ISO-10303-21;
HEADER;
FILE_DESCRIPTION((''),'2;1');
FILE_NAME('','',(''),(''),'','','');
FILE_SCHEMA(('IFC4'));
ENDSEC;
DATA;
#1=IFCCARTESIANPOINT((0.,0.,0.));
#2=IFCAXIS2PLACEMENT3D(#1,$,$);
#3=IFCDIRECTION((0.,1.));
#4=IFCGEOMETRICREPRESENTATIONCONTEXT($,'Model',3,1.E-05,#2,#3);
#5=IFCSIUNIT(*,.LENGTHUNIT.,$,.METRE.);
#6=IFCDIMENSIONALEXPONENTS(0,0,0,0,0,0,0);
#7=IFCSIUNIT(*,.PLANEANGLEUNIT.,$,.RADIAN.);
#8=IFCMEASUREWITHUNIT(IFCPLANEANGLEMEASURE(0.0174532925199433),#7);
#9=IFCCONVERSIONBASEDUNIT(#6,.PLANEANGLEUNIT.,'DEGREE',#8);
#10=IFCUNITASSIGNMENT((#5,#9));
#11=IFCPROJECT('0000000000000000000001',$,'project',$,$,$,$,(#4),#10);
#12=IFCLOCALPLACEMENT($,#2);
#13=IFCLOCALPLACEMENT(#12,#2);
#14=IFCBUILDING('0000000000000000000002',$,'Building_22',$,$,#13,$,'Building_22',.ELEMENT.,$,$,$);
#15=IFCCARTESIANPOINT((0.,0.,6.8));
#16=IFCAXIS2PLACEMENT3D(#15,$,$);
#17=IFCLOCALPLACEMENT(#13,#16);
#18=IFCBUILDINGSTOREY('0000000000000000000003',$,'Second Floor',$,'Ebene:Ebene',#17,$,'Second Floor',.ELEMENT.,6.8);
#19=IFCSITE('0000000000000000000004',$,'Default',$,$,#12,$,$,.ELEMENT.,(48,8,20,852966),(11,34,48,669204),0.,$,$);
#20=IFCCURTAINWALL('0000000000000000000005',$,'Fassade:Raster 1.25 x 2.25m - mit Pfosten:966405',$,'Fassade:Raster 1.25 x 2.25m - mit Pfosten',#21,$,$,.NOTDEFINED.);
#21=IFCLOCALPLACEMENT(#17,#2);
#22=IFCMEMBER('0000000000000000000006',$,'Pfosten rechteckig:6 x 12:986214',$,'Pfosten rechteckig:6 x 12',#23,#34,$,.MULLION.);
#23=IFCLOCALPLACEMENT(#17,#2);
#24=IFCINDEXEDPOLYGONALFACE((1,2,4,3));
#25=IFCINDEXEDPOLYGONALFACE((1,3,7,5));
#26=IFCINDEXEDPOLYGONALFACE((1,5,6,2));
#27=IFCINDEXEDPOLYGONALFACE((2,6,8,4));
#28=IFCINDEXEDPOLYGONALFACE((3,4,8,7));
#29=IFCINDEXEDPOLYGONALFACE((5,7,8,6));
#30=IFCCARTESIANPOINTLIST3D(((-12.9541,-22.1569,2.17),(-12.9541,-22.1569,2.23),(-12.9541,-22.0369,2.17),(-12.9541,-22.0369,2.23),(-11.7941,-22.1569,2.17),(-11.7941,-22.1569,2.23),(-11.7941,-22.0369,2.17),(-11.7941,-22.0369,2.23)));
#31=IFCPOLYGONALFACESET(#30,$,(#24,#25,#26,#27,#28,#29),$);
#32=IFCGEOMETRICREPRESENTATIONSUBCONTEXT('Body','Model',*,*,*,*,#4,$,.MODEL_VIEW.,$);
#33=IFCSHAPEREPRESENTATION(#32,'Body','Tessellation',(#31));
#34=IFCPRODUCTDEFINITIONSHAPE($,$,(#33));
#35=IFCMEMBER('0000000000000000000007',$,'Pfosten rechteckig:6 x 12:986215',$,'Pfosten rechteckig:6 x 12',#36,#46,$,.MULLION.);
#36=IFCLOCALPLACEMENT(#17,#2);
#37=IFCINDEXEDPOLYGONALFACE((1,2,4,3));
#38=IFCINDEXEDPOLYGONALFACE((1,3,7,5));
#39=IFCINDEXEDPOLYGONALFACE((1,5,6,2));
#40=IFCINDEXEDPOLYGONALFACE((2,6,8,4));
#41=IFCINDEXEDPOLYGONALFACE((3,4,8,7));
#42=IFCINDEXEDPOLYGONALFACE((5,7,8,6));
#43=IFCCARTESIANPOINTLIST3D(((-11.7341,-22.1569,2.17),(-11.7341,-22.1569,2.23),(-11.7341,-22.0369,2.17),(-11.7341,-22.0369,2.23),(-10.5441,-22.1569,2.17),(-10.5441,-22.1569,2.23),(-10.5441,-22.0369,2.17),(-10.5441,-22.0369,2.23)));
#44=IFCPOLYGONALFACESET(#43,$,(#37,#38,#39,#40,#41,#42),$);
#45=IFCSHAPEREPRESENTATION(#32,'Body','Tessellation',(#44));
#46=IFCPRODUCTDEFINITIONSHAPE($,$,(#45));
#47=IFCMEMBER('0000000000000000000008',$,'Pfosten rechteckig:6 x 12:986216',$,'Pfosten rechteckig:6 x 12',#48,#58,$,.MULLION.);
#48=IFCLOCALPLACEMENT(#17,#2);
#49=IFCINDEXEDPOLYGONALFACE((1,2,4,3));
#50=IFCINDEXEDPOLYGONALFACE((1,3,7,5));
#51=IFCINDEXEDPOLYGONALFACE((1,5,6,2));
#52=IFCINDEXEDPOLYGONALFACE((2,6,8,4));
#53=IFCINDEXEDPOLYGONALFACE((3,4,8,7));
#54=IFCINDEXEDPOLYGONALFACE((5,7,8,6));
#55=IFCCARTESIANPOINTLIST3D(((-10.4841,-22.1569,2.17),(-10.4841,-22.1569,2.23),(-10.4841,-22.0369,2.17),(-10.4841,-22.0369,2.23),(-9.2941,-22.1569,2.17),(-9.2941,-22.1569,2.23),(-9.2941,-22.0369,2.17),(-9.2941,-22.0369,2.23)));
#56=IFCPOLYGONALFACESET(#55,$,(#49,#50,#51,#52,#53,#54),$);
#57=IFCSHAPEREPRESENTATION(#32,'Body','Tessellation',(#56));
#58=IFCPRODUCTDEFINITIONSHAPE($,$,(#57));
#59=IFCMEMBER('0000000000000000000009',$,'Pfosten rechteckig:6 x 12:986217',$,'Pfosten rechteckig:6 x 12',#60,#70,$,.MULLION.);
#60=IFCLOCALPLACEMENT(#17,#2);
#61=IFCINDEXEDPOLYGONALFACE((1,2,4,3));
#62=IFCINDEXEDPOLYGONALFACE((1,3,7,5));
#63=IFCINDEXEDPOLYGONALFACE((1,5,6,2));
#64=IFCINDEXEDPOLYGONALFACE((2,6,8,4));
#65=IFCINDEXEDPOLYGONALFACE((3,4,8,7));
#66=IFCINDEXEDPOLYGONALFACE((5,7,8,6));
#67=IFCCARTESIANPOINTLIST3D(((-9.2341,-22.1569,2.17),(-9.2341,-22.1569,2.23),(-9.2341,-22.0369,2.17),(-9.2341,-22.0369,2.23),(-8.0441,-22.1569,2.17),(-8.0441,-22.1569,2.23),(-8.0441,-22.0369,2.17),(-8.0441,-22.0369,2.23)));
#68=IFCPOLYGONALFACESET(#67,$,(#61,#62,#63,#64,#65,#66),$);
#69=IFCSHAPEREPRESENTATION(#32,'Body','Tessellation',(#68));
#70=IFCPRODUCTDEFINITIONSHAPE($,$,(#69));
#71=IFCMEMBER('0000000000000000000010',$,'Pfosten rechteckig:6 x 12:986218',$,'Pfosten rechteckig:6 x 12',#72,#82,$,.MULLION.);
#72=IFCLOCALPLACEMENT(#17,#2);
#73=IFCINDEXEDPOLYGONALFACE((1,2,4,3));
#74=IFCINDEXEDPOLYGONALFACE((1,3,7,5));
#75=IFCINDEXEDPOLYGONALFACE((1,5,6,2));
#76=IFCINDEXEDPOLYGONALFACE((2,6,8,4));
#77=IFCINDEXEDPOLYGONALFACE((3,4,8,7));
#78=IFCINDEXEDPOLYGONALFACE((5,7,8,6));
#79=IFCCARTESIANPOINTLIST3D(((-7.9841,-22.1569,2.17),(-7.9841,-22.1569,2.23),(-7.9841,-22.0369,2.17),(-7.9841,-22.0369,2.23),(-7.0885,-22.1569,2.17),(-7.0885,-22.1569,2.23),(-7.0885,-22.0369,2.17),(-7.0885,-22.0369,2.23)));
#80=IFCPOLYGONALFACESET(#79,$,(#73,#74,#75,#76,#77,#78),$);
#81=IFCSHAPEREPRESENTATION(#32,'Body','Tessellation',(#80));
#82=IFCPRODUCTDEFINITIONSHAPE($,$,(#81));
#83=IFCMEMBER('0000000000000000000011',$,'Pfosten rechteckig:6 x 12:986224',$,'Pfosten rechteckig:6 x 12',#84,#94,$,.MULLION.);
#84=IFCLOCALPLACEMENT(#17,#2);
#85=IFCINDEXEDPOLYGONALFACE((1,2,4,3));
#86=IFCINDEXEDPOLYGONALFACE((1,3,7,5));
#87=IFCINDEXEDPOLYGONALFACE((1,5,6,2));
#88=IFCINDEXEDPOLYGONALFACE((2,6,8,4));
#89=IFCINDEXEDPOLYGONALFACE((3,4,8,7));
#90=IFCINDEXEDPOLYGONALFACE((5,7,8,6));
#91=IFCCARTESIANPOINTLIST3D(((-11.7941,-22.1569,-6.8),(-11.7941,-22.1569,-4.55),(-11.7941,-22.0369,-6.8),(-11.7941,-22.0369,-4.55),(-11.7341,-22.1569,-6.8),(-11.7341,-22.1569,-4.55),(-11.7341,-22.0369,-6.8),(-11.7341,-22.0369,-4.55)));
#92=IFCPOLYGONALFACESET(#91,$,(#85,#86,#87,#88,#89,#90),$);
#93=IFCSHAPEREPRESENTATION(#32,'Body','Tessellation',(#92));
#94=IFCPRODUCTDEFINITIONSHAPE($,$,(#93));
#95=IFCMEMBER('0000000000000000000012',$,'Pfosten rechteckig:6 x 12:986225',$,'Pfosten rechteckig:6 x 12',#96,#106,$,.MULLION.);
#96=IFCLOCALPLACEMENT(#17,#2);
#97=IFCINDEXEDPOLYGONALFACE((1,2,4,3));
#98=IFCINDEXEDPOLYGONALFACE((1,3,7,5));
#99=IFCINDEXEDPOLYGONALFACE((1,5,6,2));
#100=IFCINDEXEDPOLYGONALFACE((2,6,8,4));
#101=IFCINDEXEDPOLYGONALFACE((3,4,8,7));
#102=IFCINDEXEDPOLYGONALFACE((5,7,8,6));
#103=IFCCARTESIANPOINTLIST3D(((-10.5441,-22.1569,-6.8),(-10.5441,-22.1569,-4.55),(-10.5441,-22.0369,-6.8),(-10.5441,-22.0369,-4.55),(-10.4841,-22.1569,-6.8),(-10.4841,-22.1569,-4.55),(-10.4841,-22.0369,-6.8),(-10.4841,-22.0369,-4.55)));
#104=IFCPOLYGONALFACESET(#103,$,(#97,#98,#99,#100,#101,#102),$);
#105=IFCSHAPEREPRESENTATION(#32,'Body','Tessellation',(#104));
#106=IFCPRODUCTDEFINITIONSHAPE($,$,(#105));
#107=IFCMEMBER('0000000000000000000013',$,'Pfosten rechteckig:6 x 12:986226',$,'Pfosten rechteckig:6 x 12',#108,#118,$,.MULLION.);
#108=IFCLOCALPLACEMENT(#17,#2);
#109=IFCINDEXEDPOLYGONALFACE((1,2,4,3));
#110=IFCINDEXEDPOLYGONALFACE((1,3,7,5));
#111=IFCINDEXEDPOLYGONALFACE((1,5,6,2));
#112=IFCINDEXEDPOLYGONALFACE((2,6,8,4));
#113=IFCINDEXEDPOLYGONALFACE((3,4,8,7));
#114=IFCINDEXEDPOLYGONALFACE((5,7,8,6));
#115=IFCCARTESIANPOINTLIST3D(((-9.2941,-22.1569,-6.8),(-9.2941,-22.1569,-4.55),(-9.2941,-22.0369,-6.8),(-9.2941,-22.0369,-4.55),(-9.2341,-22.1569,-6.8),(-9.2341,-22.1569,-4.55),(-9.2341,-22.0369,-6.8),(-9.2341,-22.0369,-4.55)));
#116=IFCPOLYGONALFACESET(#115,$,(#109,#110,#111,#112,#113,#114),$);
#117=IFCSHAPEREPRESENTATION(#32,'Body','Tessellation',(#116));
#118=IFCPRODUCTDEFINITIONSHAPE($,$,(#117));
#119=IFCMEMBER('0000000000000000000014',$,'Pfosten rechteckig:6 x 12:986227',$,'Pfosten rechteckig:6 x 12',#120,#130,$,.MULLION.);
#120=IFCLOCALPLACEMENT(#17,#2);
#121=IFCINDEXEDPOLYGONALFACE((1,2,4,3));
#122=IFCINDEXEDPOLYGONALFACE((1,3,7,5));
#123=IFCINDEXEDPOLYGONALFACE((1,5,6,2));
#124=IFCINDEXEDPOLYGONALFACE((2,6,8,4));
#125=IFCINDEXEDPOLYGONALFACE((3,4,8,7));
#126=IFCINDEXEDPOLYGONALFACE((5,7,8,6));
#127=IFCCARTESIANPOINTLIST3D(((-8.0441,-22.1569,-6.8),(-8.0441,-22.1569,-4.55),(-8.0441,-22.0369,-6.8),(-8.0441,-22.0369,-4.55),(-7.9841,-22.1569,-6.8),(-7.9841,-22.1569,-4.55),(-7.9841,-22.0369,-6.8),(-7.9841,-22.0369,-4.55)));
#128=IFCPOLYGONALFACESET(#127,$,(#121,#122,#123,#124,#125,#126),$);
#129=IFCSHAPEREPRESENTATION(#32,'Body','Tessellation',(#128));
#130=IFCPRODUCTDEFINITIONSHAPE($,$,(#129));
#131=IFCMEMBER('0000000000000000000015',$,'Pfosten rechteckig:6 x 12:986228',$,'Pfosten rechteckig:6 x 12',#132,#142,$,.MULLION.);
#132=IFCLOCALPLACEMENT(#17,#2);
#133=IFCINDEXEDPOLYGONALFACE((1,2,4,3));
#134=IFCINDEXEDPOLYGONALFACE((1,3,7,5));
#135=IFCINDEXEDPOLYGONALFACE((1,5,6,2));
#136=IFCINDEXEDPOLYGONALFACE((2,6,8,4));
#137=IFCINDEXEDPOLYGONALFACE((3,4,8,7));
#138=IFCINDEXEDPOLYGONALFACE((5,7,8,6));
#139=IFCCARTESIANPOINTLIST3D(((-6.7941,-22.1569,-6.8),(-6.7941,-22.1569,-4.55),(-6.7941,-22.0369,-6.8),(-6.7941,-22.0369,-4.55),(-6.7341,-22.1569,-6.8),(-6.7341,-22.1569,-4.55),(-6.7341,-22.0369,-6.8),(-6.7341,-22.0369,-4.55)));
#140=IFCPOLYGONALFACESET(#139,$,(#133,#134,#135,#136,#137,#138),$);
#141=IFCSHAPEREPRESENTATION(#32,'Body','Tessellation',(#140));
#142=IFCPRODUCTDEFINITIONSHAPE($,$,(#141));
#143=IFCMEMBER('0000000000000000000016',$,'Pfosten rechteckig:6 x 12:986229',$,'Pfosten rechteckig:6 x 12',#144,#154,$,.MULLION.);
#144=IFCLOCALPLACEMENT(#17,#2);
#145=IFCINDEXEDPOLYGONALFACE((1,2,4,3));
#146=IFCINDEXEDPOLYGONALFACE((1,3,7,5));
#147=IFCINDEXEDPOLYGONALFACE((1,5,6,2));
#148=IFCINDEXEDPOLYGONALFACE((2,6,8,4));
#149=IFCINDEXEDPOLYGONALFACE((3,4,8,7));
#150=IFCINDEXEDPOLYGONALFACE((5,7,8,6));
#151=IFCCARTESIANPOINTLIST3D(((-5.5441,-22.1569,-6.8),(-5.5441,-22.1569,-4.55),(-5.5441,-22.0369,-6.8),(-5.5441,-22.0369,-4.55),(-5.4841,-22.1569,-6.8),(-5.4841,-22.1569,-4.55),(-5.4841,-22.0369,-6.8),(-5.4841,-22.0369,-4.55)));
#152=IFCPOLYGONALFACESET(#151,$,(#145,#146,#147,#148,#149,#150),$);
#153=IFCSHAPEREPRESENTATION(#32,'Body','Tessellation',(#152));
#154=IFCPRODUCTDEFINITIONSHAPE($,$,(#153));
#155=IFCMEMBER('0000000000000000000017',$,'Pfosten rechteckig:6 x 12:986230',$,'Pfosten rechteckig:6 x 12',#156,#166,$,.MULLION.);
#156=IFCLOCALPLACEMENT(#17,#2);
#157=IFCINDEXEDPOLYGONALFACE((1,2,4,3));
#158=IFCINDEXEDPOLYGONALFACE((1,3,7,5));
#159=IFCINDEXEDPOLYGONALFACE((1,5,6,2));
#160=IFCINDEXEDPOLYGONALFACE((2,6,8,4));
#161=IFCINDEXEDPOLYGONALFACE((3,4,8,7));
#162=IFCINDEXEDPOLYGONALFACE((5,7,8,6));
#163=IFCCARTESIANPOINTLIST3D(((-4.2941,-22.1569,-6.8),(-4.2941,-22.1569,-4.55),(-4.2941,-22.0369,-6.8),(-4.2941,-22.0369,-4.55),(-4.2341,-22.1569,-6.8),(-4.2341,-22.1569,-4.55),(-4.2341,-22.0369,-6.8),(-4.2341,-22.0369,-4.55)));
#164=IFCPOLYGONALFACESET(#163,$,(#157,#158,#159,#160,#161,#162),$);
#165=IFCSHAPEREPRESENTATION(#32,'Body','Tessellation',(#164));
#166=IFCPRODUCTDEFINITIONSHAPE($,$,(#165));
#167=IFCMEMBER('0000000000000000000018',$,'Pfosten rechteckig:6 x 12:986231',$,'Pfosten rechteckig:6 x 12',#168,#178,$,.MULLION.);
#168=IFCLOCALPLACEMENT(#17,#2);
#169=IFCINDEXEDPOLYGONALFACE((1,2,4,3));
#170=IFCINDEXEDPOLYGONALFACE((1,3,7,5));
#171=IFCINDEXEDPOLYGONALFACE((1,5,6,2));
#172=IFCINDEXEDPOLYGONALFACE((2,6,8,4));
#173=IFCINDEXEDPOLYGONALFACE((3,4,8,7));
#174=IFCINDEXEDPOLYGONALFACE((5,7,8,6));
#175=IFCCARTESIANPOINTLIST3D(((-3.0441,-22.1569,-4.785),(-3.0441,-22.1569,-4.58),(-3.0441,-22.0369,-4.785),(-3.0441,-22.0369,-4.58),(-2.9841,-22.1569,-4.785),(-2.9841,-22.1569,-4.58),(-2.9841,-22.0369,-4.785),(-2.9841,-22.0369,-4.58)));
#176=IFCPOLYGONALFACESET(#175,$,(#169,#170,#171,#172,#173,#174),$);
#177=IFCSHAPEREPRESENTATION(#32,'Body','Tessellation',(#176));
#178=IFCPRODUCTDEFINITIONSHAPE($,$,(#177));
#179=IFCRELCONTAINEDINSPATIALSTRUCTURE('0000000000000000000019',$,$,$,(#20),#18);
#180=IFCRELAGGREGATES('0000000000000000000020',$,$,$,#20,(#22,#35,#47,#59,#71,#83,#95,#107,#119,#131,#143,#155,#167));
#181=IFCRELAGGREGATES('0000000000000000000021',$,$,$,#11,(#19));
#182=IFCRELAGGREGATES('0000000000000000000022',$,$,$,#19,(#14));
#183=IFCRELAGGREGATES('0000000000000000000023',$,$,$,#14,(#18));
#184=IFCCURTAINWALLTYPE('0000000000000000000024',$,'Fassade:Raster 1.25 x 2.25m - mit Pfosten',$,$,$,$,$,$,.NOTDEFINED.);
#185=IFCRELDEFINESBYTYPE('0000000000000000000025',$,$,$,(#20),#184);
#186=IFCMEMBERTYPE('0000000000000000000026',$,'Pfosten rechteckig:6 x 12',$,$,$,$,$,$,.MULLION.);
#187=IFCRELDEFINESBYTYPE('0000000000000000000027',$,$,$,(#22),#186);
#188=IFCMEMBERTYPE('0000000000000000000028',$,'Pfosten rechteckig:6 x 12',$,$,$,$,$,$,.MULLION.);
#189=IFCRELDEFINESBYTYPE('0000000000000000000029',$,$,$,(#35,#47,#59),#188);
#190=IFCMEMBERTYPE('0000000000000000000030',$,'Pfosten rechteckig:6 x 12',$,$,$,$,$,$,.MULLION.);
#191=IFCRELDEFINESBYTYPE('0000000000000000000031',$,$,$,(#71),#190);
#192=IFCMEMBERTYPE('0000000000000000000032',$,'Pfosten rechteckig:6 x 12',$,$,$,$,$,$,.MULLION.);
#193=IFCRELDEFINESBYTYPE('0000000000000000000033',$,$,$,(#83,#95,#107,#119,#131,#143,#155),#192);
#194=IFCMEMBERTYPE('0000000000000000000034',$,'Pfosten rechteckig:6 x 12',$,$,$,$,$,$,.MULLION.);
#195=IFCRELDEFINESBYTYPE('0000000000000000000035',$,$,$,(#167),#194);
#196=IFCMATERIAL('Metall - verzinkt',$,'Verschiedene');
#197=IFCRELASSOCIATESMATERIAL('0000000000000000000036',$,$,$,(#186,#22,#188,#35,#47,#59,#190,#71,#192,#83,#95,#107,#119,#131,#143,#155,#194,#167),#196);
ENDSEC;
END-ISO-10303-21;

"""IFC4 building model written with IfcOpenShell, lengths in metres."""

from ifc_helpers import new_model, entity, si_unit, converted_unit, direction, frame, origin, place, context, subcontext, project, spatial, indexed_curve, outline, extrude, source, transform, mapped, material, type_object, type_shapes, element, aggregate, save


model = new_model("IFC4")

# Units and contexts
model_context = context("Model", 3, precision=1e-05, world=origin(), true_north=direction((0.0, 1.0)))
body_context = subcontext(model_context, "Body", "Model", "MODEL_VIEW")
ifc_project = project(units=[si_unit("LENGTHUNIT", "METRE"), converted_unit("PLANEANGLEUNIT", "DEGREE", entity("IfcPlaneAngleMeasure", 0.0174532925199433), si_unit("PLANEANGLEUNIT", "RADIAN"), dimensions=[0, 0, 0, 0, 0, 0, 0])], contexts=[model_context])

# Site, building, storey
site_placement = place(None, origin())
site = spatial("IfcSite", under=ifc_project, at=site_placement, Name="Default", CompositionType="ELEMENT", RefLatitude=(48, 8, 20, 852966), RefLongitude=(11, 34, 48, 669204), RefElevation=0.0)
building_placement = place(site_placement, origin())
building = spatial("IfcBuilding", under=site, at=building_placement, Name="Building_22", LongName="Building_22", CompositionType="ELEMENT")
storey_placement = place(building_placement, frame((0.0, 0.0, 6.8)))
storey = spatial("IfcBuildingStorey", under=building, at=storey_placement, Name="Second Floor", ObjectType="Ebene:Ebene", LongName="Second Floor", CompositionType="ELEMENT", Elevation=6.8)

# Curtain wall, members
curtain_wall_type = type_object("IfcCurtainWallType", Name="Fassade:Raster 1.25 x 2.25m - mit Pfosten", PredefinedType="NOTDEFINED")
curtain_wall_placement = place(storey_placement, frame((0.0, 0.0, -6.8)))
curtain_wall = element("IfcCurtainWall", 1, at=curtain_wall_placement, inside=storey, type_object=curtain_wall_type, Name="Fassade:Raster 1.25 x 2.25m - mit Pfosten:966405", ObjectType="Fassade:Raster 1.25 x 2.25m - mit Pfosten", PredefinedType="NOTDEFINED")
ifc_material = material(Name="Metall - verzinkt", Category="Verschiedene")
member_type_1 = type_object("IfcMemberType", Name="Pfosten rechteckig:6 x 12", PredefinedType="MULLION", material=ifc_material)
shared_shape_1 = source(origin(), body_context, "Body", "SweptSolid", [
    extrude(outline(indexed_curve([(-0.03, -0.06), (0.03, -0.06), (0.03, 0.06), (-0.03, 0.06), (-0.03, -0.06)], self_intersect=False)), frame((0.0, 0.0, -1.16), z_axis=(0.0, 0.0, 1.0), x_axis=(-1.0, 0.0, 0.0)), (0.0, 0.0, 1.0), 1.16),
])
type_shapes(member_type_1, [shared_shape_1])
member_1_placement = place(curtain_wall_placement, frame((-11.7941, -22.0969, 9.0), z_axis=(1.0, 0.0, 0.0), x_axis=(0.0, 0.0, 1.0)))
member_1 = element("IfcMember", 2, at=member_1_placement, type_object=member_type_1, material=ifc_material, Name="Pfosten rechteckig:6 x 12:986214", ObjectType="Pfosten rechteckig:6 x 12", PredefinedType="MULLION", context=body_context, shape_type="MappedRepresentation", body=[
    mapped(shared_shape_1, transform((0.0, 0.0, 0.0), scale=1.0)),
])
member_type_2 = type_object("IfcMemberType", Name="Pfosten rechteckig:6 x 12", PredefinedType="MULLION", material=ifc_material)
shared_shape_2 = source(origin(), body_context, "Body", "SweptSolid", [
    extrude(outline(indexed_curve([(-0.03, -0.06), (0.03, -0.06), (0.03, 0.06), (-0.03, 0.06), (-0.03, -0.06)], self_intersect=False)), frame((0.0, 0.0, -1.19), z_axis=(0.0, 0.0, 1.0), x_axis=(-1.0, 0.0, 0.0)), (0.0, 0.0, 1.0), 1.19),
])
type_shapes(member_type_2, [shared_shape_2])
member_2_placement = place(curtain_wall_placement, frame((-10.5441, -22.0969, 9.0), z_axis=(1.0, 0.0, 0.0), x_axis=(0.0, 0.0, 1.0)))
member_2 = element("IfcMember", 3, at=member_2_placement, type_object=member_type_2, material=ifc_material, Name="Pfosten rechteckig:6 x 12:986215", ObjectType="Pfosten rechteckig:6 x 12", PredefinedType="MULLION", context=body_context, shape_type="MappedRepresentation", body=[
    mapped(shared_shape_2, transform((0.0, 0.0, 0.0), scale=1.0)),
])
member_3_placement = place(curtain_wall_placement, frame((-9.2941, -22.0969, 9.0), z_axis=(1.0, 0.0, 0.0), x_axis=(0.0, 0.0, 1.0)))
member_3 = element("IfcMember", 4, at=member_3_placement, type_object=member_type_2, material=ifc_material, Name="Pfosten rechteckig:6 x 12:986216", ObjectType="Pfosten rechteckig:6 x 12", PredefinedType="MULLION", context=body_context, shape_type="MappedRepresentation", body=[
    mapped(shared_shape_2, transform((0.0, 0.0, 0.0), scale=1.0)),
])
member_4_placement = place(curtain_wall_placement, frame((-8.0441, -22.0969, 9.0), z_axis=(1.0, 0.0, 0.0), x_axis=(0.0, 0.0, 1.0)))
member_4 = element("IfcMember", 5, at=member_4_placement, type_object=member_type_2, material=ifc_material, Name="Pfosten rechteckig:6 x 12:986217", ObjectType="Pfosten rechteckig:6 x 12", PredefinedType="MULLION", context=body_context, shape_type="MappedRepresentation", body=[
    mapped(shared_shape_2, transform((0.0, 0.0, 0.0), scale=1.0)),
])
member_type_3 = type_object("IfcMemberType", Name="Pfosten rechteckig:6 x 12", PredefinedType="MULLION", material=ifc_material)
shared_shape_3 = source(origin(), body_context, "Body", "SweptSolid", [
    extrude(outline(indexed_curve([(-0.03, -0.06), (0.03, -0.06), (0.03, 0.06), (-0.03, 0.06), (-0.03, -0.06)], self_intersect=False)), frame((0.0, 0.0, -0.8956), z_axis=(0.0, 0.0, 1.0), x_axis=(-1.0, 0.0, 0.0)), (0.0, 0.0, 1.0), 0.8956),
])
type_shapes(member_type_3, [shared_shape_3])
member_5_placement = place(curtain_wall_placement, frame((-7.0885, -22.0969, 9.0), z_axis=(1.0, 0.0, 0.0), x_axis=(0.0, 0.0, 1.0)))
member_5 = element("IfcMember", 6, at=member_5_placement, type_object=member_type_3, material=ifc_material, Name="Pfosten rechteckig:6 x 12:986218", ObjectType="Pfosten rechteckig:6 x 12", PredefinedType="MULLION", context=body_context, shape_type="MappedRepresentation", body=[
    mapped(shared_shape_3, transform((0.0, 0.0, 0.0), scale=1.0)),
])
member_type_4 = type_object("IfcMemberType", Name="Pfosten rechteckig:6 x 12", PredefinedType="MULLION", material=ifc_material)
shared_shape_4 = source(origin(), body_context, "Body", "SweptSolid", [
    extrude(outline(indexed_curve([(-0.03, -0.06), (0.03, -0.06), (0.03, 0.06), (-0.03, 0.06), (-0.03, -0.06)], self_intersect=False)), frame((0.0, 0.0, -2.25), z_axis=(0.0, 0.0, 1.0), x_axis=(-1.0, 0.0, 0.0)), (0.0, 0.0, 1.0), 2.25),
])
type_shapes(member_type_4, [shared_shape_4])
member_6_placement = place(curtain_wall_placement, frame((-11.7641, -22.0969, 0.0), z_axis=(0.0, 0.0, -1.0), x_axis=(1.0, 0.0, 0.0)))
member_6 = element("IfcMember", 7, at=member_6_placement, type_object=member_type_4, material=ifc_material, Name="Pfosten rechteckig:6 x 12:986224", ObjectType="Pfosten rechteckig:6 x 12", PredefinedType="MULLION", context=body_context, shape_type="MappedRepresentation", body=[
    mapped(shared_shape_4, transform((0.0, 0.0, 0.0), scale=1.0)),
])
member_7_placement = place(curtain_wall_placement, frame((-10.5141, -22.0969, 0.0), z_axis=(0.0, 0.0, -1.0), x_axis=(1.0, 0.0, 0.0)))
member_7 = element("IfcMember", 8, at=member_7_placement, type_object=member_type_4, material=ifc_material, Name="Pfosten rechteckig:6 x 12:986225", ObjectType="Pfosten rechteckig:6 x 12", PredefinedType="MULLION", context=body_context, shape_type="MappedRepresentation", body=[
    mapped(shared_shape_4, transform((0.0, 0.0, 0.0), scale=1.0)),
])
member_8_placement = place(curtain_wall_placement, frame((-9.2641, -22.0969, 0.0), z_axis=(0.0, 0.0, -1.0), x_axis=(1.0, 0.0, 0.0)))
member_8 = element("IfcMember", 9, at=member_8_placement, type_object=member_type_4, material=ifc_material, Name="Pfosten rechteckig:6 x 12:986226", ObjectType="Pfosten rechteckig:6 x 12", PredefinedType="MULLION", context=body_context, shape_type="MappedRepresentation", body=[
    mapped(shared_shape_4, transform((0.0, 0.0, 0.0), scale=1.0)),
])
member_9_placement = place(curtain_wall_placement, frame((-8.0141, -22.0969, 0.0), z_axis=(0.0, 0.0, -1.0), x_axis=(1.0, 0.0, 0.0)))
member_9 = element("IfcMember", 10, at=member_9_placement, type_object=member_type_4, material=ifc_material, Name="Pfosten rechteckig:6 x 12:986227", ObjectType="Pfosten rechteckig:6 x 12", PredefinedType="MULLION", context=body_context, shape_type="MappedRepresentation", body=[
    mapped(shared_shape_4, transform((0.0, 0.0, 0.0), scale=1.0)),
])
member_10_placement = place(curtain_wall_placement, frame((-6.7641, -22.0969, 0.0), z_axis=(0.0, 0.0, -1.0), x_axis=(1.0, 0.0, 0.0)))
member_10 = element("IfcMember", 11, at=member_10_placement, type_object=member_type_4, material=ifc_material, Name="Pfosten rechteckig:6 x 12:986228", ObjectType="Pfosten rechteckig:6 x 12", PredefinedType="MULLION", context=body_context, shape_type="MappedRepresentation", body=[
    mapped(shared_shape_4, transform((0.0, 0.0, 0.0), scale=1.0)),
])
member_11_placement = place(curtain_wall_placement, frame((-5.5141, -22.0969, 0.0), z_axis=(0.0, 0.0, -1.0), x_axis=(1.0, 0.0, 0.0)))
member_11 = element("IfcMember", 12, at=member_11_placement, type_object=member_type_4, material=ifc_material, Name="Pfosten rechteckig:6 x 12:986229", ObjectType="Pfosten rechteckig:6 x 12", PredefinedType="MULLION", context=body_context, shape_type="MappedRepresentation", body=[
    mapped(shared_shape_4, transform((0.0, 0.0, 0.0), scale=1.0)),
])
member_12_placement = place(curtain_wall_placement, frame((-4.2641, -22.0969, 0.0), z_axis=(0.0, 0.0, -1.0), x_axis=(1.0, 0.0, 0.0)))
member_12 = element("IfcMember", 13, at=member_12_placement, type_object=member_type_4, material=ifc_material, Name="Pfosten rechteckig:6 x 12:986230", ObjectType="Pfosten rechteckig:6 x 12", PredefinedType="MULLION", context=body_context, shape_type="MappedRepresentation", body=[
    mapped(shared_shape_4, transform((0.0, 0.0, 0.0), scale=1.0)),
])
member_type_5 = type_object("IfcMemberType", Name="Pfosten rechteckig:6 x 12", PredefinedType="MULLION", material=ifc_material)
shared_shape_5 = source(origin(), body_context, "Body", "SweptSolid", [
    extrude(outline(indexed_curve([(-0.03, -0.06), (0.03, -0.06), (0.03, 0.06), (-0.03, 0.06), (-0.03, -0.06)], self_intersect=False)), frame((0.0, 0.0, -0.205), z_axis=(0.0, 0.0, 1.0), x_axis=(-1.0, 0.0, 0.0)), (0.0, 0.0, 1.0), 0.205),
])
type_shapes(member_type_5, [shared_shape_5])
member_13_placement = place(curtain_wall_placement, frame((-3.0141, -22.0969, 2.015), z_axis=(0.0, 0.0, -1.0), x_axis=(1.0, 0.0, 0.0)))
member_13 = element("IfcMember", 14, at=member_13_placement, type_object=member_type_5, material=ifc_material, Name="Pfosten rechteckig:6 x 12:986231", ObjectType="Pfosten rechteckig:6 x 12", PredefinedType="MULLION", context=body_context, shape_type="MappedRepresentation", body=[
    mapped(shared_shape_5, transform((0.0, 0.0, 0.0), scale=1.0)),
])
aggregate(curtain_wall, [member_1, member_2, member_3, member_4, member_5, member_6, member_7, member_8, member_9, member_10, member_11, member_12, member_13])

save(model, "model.ifc")
